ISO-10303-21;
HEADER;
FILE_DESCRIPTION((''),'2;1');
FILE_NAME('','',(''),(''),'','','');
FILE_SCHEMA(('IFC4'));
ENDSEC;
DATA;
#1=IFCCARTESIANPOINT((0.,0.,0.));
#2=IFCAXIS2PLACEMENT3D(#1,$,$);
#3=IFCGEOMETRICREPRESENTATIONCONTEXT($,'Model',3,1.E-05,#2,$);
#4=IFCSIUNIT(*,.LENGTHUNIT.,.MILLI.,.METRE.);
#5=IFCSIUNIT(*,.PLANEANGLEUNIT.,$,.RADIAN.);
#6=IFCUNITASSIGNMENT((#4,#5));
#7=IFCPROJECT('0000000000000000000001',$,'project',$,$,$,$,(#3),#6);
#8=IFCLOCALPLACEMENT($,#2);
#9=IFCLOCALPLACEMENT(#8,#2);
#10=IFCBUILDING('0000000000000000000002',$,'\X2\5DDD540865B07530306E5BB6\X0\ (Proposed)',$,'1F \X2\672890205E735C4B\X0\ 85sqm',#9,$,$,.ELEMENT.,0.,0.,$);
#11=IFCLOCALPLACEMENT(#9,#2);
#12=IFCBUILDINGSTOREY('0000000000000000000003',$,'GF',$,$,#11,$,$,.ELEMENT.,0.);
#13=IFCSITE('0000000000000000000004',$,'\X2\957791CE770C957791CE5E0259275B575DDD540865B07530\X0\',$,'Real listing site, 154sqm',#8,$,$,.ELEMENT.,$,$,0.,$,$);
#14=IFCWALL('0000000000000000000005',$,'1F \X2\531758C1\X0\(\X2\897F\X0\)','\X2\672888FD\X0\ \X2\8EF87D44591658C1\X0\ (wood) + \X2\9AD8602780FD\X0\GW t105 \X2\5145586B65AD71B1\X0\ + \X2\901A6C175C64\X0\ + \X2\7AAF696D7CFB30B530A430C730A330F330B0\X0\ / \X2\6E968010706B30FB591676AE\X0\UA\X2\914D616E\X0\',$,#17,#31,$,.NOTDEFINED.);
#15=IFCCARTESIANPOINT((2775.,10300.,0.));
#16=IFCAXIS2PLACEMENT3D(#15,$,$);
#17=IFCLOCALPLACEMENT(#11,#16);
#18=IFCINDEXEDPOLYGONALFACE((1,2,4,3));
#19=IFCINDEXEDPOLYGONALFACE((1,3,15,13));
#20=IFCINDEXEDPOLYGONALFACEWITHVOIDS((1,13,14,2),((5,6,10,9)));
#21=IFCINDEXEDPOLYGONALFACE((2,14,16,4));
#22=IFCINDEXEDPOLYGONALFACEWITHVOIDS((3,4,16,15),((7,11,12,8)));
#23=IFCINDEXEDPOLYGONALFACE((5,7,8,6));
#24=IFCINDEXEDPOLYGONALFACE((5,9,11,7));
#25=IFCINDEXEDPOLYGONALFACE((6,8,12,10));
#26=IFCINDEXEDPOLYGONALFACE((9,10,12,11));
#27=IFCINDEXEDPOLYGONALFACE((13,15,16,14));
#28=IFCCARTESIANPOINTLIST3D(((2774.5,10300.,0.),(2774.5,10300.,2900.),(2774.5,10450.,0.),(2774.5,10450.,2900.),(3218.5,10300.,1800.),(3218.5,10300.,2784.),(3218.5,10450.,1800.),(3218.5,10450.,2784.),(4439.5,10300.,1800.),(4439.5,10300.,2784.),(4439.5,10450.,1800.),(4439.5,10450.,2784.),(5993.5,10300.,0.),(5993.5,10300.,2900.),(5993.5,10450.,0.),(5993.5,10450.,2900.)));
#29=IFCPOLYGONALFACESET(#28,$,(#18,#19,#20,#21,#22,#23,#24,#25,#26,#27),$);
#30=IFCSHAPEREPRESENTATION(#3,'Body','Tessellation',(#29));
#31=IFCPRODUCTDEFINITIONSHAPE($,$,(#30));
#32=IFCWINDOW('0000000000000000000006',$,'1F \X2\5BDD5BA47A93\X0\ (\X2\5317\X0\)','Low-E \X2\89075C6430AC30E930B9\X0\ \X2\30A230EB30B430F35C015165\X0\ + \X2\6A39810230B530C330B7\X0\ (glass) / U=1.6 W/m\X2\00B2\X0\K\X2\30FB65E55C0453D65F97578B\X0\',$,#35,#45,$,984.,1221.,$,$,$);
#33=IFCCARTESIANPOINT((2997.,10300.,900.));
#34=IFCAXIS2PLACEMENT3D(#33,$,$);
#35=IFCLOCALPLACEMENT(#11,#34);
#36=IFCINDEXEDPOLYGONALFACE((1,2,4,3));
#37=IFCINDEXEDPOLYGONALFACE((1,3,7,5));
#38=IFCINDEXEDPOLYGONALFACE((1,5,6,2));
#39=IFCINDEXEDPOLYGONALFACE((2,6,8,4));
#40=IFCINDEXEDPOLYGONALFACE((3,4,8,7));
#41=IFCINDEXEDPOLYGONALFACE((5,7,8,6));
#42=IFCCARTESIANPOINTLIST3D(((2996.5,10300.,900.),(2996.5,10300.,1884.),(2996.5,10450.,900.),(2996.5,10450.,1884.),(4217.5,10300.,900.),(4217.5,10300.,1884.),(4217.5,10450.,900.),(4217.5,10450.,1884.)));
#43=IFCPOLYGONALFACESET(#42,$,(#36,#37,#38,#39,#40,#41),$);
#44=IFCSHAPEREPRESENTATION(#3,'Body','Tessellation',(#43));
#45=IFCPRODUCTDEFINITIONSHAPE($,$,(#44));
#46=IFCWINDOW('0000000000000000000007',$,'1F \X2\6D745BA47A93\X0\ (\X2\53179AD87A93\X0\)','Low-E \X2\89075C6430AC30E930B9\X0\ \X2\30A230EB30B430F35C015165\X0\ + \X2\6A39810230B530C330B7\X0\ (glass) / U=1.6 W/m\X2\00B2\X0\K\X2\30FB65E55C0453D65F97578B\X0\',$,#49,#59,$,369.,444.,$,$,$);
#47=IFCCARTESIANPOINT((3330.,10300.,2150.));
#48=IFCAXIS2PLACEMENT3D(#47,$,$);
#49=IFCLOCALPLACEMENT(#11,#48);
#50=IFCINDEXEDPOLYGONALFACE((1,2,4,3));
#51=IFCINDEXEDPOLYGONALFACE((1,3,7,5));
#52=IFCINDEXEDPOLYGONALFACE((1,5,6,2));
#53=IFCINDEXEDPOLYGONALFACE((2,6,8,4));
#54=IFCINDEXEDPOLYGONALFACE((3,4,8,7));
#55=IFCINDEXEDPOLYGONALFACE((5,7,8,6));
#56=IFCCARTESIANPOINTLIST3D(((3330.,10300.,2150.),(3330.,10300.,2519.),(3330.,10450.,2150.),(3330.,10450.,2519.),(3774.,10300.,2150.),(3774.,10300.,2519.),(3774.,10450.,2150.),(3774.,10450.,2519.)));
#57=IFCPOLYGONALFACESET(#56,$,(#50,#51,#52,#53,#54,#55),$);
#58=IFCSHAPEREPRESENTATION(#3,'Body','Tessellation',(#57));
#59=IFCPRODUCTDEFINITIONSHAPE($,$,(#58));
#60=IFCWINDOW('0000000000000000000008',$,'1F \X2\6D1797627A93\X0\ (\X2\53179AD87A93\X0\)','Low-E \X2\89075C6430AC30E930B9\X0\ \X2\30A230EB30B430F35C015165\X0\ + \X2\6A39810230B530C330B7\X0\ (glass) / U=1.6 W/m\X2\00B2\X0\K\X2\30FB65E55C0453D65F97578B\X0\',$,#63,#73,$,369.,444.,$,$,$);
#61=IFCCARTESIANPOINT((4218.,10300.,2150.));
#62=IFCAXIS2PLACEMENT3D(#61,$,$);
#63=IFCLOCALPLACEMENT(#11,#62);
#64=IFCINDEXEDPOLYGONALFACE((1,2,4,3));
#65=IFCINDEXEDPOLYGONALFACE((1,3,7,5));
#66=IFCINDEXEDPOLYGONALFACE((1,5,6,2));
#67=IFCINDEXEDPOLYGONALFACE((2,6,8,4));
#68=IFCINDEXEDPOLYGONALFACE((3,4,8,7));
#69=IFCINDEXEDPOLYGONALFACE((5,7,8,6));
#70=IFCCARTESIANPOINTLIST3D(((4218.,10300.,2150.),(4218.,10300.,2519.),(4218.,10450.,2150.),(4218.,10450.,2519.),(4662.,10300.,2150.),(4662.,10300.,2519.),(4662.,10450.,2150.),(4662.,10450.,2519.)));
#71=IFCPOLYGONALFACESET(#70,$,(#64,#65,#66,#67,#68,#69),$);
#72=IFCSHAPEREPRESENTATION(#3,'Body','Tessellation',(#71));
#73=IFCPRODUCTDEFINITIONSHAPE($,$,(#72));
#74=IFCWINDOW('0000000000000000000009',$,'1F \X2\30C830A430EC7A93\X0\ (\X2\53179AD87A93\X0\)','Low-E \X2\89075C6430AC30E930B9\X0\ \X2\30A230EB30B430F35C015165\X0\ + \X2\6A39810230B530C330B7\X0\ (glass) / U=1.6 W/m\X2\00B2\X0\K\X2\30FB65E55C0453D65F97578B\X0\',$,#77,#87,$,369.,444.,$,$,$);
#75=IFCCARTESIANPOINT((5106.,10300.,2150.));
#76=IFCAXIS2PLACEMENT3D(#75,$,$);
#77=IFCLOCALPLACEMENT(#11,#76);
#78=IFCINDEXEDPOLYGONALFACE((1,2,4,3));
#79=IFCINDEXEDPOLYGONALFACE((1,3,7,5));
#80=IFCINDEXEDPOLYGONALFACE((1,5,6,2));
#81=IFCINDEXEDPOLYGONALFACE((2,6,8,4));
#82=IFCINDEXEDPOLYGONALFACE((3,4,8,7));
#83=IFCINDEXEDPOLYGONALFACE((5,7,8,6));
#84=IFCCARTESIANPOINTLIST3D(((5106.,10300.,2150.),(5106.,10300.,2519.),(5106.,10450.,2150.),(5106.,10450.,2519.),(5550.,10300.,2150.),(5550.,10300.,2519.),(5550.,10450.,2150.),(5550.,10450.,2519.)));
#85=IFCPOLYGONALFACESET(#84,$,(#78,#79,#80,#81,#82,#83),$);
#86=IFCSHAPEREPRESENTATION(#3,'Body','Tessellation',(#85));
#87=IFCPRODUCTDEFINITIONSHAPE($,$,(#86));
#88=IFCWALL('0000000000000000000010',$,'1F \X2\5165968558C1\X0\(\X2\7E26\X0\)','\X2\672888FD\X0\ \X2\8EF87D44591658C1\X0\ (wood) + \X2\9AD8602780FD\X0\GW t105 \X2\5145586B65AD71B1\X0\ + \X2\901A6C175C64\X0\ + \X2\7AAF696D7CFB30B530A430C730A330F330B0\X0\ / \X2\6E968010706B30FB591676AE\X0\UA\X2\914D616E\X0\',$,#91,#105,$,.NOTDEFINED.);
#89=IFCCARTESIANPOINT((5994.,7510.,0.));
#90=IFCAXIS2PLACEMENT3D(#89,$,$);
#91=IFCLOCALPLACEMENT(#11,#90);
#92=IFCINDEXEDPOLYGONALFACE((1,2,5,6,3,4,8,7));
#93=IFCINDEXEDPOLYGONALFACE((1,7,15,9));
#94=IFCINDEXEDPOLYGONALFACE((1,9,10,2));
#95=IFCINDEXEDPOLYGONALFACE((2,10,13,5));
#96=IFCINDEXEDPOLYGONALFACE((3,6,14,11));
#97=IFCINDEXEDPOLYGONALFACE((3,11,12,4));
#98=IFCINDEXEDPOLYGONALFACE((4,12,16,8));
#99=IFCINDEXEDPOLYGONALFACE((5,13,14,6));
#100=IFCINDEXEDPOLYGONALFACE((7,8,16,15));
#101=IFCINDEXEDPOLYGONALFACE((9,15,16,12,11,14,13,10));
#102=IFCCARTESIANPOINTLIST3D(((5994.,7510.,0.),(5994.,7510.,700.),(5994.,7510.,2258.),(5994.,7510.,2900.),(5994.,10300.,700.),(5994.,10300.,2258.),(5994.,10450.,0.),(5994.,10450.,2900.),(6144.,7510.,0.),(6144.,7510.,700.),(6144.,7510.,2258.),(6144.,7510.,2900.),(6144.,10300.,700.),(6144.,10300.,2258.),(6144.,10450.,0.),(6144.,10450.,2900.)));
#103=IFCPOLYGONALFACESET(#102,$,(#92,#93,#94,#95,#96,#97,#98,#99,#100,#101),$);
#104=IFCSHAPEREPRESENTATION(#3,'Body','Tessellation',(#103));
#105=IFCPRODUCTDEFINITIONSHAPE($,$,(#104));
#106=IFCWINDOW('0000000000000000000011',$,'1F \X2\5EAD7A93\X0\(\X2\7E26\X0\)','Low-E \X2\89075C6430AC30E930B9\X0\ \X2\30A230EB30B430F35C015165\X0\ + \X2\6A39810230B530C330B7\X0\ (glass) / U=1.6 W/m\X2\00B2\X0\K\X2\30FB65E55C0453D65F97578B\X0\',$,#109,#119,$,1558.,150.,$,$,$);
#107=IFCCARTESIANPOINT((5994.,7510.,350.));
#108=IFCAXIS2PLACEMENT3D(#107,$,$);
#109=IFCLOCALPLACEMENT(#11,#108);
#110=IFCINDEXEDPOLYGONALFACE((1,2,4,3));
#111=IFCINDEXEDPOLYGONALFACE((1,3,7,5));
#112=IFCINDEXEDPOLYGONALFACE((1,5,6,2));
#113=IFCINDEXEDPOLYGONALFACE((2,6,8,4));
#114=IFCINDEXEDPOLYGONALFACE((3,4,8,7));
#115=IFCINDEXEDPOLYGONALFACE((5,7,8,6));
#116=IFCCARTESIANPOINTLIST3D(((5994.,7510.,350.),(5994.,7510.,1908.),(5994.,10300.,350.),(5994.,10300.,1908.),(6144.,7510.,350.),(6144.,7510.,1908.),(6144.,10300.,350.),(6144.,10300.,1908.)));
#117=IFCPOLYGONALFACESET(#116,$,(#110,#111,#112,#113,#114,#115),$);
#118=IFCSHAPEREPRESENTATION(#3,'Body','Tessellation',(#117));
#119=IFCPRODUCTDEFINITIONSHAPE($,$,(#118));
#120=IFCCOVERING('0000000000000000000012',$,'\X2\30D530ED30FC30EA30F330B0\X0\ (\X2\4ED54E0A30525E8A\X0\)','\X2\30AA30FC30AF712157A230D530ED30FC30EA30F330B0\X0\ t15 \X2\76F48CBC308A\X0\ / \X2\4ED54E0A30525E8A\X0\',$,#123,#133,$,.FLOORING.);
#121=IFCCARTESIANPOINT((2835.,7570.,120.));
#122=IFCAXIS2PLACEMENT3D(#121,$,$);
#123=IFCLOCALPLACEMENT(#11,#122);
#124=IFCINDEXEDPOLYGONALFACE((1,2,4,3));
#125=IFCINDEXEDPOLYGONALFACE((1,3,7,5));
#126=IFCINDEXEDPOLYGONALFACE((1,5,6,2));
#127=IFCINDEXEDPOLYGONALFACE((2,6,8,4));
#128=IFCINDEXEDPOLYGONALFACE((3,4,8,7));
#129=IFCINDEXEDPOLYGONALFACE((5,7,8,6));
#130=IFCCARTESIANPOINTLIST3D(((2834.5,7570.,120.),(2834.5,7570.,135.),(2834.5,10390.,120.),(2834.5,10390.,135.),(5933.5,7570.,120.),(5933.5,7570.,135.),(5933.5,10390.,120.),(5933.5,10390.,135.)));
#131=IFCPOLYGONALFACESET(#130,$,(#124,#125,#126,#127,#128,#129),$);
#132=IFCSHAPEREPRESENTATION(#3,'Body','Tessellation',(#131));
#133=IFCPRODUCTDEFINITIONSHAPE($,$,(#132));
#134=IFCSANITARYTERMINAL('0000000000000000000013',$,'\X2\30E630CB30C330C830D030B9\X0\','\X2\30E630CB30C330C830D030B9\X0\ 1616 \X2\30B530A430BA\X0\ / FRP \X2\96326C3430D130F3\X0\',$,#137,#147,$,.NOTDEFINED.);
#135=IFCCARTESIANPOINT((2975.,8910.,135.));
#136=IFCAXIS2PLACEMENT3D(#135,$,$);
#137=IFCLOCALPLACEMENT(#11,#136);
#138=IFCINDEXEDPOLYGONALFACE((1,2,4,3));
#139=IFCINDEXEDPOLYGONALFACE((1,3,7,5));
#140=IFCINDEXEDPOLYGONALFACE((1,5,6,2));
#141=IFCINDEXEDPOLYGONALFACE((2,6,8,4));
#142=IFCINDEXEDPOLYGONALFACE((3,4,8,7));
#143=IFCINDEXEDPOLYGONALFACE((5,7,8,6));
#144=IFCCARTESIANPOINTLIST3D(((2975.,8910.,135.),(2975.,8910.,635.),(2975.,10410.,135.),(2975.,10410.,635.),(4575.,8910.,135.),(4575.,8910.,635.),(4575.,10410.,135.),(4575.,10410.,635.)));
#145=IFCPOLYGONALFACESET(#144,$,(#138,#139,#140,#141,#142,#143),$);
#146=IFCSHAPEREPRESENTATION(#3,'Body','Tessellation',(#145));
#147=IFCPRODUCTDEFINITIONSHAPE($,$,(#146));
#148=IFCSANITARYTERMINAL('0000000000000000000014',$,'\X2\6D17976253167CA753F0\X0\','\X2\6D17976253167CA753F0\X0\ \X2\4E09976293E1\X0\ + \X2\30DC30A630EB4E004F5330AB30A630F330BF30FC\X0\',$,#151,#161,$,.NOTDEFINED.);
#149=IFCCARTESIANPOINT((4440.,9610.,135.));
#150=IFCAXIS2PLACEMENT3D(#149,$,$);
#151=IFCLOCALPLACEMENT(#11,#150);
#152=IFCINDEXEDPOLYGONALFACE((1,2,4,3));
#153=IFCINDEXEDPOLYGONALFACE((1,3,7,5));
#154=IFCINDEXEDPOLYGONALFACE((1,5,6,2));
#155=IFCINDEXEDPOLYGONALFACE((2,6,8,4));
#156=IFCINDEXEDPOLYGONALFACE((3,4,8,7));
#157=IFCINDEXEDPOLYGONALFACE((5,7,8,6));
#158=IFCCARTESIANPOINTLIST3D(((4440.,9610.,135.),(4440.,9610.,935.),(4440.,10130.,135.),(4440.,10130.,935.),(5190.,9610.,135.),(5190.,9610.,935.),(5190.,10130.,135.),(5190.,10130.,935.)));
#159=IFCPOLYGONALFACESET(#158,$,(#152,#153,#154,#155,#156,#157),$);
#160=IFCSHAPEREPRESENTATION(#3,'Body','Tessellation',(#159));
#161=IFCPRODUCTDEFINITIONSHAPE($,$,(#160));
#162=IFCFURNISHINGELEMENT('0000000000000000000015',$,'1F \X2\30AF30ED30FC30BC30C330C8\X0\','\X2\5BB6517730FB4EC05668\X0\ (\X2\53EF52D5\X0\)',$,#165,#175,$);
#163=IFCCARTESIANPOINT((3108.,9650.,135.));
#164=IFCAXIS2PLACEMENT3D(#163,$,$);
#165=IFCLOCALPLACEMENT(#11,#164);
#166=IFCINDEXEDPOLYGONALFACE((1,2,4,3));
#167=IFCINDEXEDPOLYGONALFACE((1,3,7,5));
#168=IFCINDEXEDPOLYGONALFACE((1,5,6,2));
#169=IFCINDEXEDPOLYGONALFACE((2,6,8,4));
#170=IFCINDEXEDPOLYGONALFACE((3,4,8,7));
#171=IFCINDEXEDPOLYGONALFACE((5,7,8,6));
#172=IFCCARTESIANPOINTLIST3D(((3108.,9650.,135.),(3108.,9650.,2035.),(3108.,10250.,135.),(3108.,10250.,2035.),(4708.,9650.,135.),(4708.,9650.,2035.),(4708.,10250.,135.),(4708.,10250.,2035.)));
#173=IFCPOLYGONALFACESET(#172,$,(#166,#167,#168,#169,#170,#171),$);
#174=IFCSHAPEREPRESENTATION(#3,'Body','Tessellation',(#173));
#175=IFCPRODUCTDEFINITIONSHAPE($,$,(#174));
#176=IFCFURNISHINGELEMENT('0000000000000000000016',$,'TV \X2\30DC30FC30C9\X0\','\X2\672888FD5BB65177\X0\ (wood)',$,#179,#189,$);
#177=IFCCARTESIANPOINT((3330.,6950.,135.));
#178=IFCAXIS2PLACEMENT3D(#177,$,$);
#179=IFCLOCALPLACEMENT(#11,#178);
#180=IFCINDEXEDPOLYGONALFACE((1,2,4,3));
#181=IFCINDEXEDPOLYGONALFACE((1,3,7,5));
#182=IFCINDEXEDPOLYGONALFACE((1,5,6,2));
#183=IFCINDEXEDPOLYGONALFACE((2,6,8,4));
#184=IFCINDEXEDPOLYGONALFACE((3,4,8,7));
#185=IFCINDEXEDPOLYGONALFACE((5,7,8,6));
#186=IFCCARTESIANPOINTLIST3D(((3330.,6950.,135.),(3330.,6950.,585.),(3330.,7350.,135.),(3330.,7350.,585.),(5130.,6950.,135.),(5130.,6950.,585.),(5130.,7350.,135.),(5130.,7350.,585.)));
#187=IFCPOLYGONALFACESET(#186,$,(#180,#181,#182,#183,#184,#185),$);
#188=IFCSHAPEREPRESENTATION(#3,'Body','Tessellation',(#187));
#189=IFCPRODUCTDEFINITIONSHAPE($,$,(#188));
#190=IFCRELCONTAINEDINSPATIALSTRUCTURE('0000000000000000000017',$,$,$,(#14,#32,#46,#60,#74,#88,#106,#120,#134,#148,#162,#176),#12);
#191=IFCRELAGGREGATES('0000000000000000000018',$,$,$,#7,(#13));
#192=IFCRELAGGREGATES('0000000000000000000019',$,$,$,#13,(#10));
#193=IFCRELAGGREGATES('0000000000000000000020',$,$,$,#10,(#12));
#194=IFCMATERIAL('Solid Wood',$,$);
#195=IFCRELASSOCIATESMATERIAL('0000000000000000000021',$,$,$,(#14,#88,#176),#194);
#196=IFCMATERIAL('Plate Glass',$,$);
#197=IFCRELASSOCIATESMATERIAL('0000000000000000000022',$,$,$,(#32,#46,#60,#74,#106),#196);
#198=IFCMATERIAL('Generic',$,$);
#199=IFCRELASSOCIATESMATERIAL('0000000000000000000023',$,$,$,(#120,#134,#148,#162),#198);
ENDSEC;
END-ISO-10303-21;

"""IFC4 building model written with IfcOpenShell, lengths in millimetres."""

from ifc_helpers import new_model, si_unit, frame, frame_2d, origin, place, context, project, spatial, rectangle, extrude, material, element, fill, save


model = new_model("IFC4")

# Units and contexts
model_context = context("Model", 3, precision=1e-05, world=origin())
ifc_project = project(units=[si_unit("LENGTHUNIT", "METRE", prefix="MILLI"), si_unit("PLANEANGLEUNIT", "RADIAN")], contexts=[model_context])

# Site, building, storey
site_placement = place(None, origin())
site = spatial("IfcSite", under=ifc_project, at=site_placement, Name="長野県長野市大字川合新田", ObjectType="Real listing site, 154sqm", CompositionType="ELEMENT", RefElevation=0.0)
building_placement = place(site_placement, origin())
building = spatial("IfcBuilding", under=site, at=building_placement, Name="川合新田の家 (Proposed)", ObjectType="1F 木造平屋 85sqm", CompositionType="ELEMENT", ElevationOfRefHeight=0.0, ElevationOfTerrain=0.0)
storey_placement = place(building_placement, origin())
storey = spatial("IfcBuildingStorey", under=building, at=storey_placement, Name="GF", CompositionType="ELEMENT", Elevation=0.0)

# Shared definitions
ifc_material_1 = material(Name="Solid Wood")

# Wall, openings, windows
wall_1_placement = place(storey_placement, frame((2775.0, 10300.0, 0.0)))
wall_1 = element("IfcWall", 1, at=wall_1_placement, inside=storey, material=ifc_material_1, Name="1F 北壁(西)", Description="木製 軸組外壁 (wood) + 高性能GW t105 充填断熱 + 通気層 + 窯業系サイディング / 準耐火・外皮UA配慮", PredefinedType="NOTDEFINED", context=model_context, shape_type="SweptSolid", body=[
    extrude(rectangle(XDim=3219.0, YDim=150.0, at=frame_2d((1609.0, 75.0))), frame((2775.0, 10300.0, 0.0)), (0.0, 0.0, 1.0), 2900.0),
])
opening_1_placement = place(storey_placement, frame((2997.0, 10300.0, 900.0)))
opening_1 = element("IfcOpeningElement", 2, at=opening_1_placement, cuts=wall_1, PredefinedType="NOTDEFINED", context=model_context, shape_type="SweptSolid", body=[
    extrude(rectangle(XDim=1221.0, YDim=150.0, at=frame_2d((610.0, 75.0))), frame((2997.0, 10300.0, 900.0)), (0.0, 0.0, 1.0), 984.0),
])
opening_2_placement = place(storey_placement, frame((3330.0, 10300.0, 2150.0)))
opening_2 = element("IfcOpeningElement", 3, at=opening_2_placement, cuts=wall_1, PredefinedType="NOTDEFINED", context=model_context, shape_type="SweptSolid", body=[
    extrude(rectangle(XDim=444.0, YDim=150.0, at=frame_2d((222.0, 75.0))), frame((3330.0, 10300.0, 2150.0)), (0.0, 0.0, 1.0), 369.0),
])
opening_3_placement = place(storey_placement, frame((4218.0, 10300.0, 2150.0)))
opening_3 = element("IfcOpeningElement", 4, at=opening_3_placement, cuts=wall_1, PredefinedType="NOTDEFINED", context=model_context, shape_type="SweptSolid", body=[
    extrude(rectangle(XDim=444.0, YDim=150.0, at=frame_2d((222.0, 75.0))), frame((4218.0, 10300.0, 2150.0)), (0.0, 0.0, 1.0), 369.0),
])
opening_4_placement = place(storey_placement, frame((5106.0, 10300.0, 2150.0)))
opening_4 = element("IfcOpeningElement", 5, at=opening_4_placement, cuts=wall_1, PredefinedType="NOTDEFINED", context=model_context, shape_type="SweptSolid", body=[
    extrude(rectangle(XDim=444.0, YDim=150.0, at=frame_2d((222.0, 75.0))), frame((5106.0, 10300.0, 2150.0)), (0.0, 0.0, 1.0), 369.0),
])
ifc_material_2 = material(Name="Plate Glass")
window_1_placement = place(storey_placement, frame((2997.0, 10300.0, 900.0)))
window_1 = element("IfcWindow", 6, at=window_1_placement, inside=storey, material=ifc_material_2, Name="1F 寝室窓 (北)", Description="Low-E 複層ガラス アルゴン封入 + 樹脂サッシ (glass) / U=1.6 W/m²K・日射取得型", OverallHeight=984.0, OverallWidth=1221.0, context=model_context, shape_type="SweptSolid", body=[
    extrude(rectangle(XDim=1221.0, YDim=150.0, at=frame_2d((610.0, 75.0))), frame((2997.0, 10300.0, 900.0)), (0.0, 0.0, 1.0), 984.0),
])
fill(opening_1, window_1)
window_2_placement = place(storey_placement, frame((3330.0, 10300.0, 2150.0)))
window_2 = element("IfcWindow", 7, at=window_2_placement, inside=storey, material=ifc_material_2, Name="1F 浴室窓 (北高窓)", Description="Low-E 複層ガラス アルゴン封入 + 樹脂サッシ (glass) / U=1.6 W/m²K・日射取得型", OverallHeight=369.0, OverallWidth=444.0, context=model_context, shape_type="SweptSolid", body=[
    extrude(rectangle(XDim=444.0, YDim=150.0, at=frame_2d((222.0, 75.0))), frame((3330.0, 10300.0, 2150.0)), (0.0, 0.0, 1.0), 369.0),
])
fill(opening_2, window_2)
window_3_placement = place(storey_placement, frame((4218.0, 10300.0, 2150.0)))
window_3 = element("IfcWindow", 8, at=window_3_placement, inside=storey, material=ifc_material_2, Name="1F 洗面窓 (北高窓)", Description="Low-E 複層ガラス アルゴン封入 + 樹脂サッシ (glass) / U=1.6 W/m²K・日射取得型", OverallHeight=369.0, OverallWidth=444.0, context=model_context, shape_type="SweptSolid", body=[
    extrude(rectangle(XDim=444.0, YDim=150.0, at=frame_2d((222.0, 75.0))), frame((4218.0, 10300.0, 2150.0)), (0.0, 0.0, 1.0), 369.0),
])
fill(opening_3, window_3)
window_4_placement = place(storey_placement, frame((5106.0, 10300.0, 2150.0)))
window_4 = element("IfcWindow", 9, at=window_4_placement, inside=storey, material=ifc_material_2, Name="1F トイレ窓 (北高窓)", Description="Low-E 複層ガラス アルゴン封入 + 樹脂サッシ (glass) / U=1.6 W/m²K・日射取得型", OverallHeight=369.0, OverallWidth=444.0, context=model_context, shape_type="SweptSolid", body=[
    extrude(rectangle(XDim=444.0, YDim=150.0, at=frame_2d((222.0, 75.0))), frame((5106.0, 10300.0, 2150.0)), (0.0, 0.0, 1.0), 369.0),
])
fill(opening_4, window_4)

# Wall, opening, window
wall_2_placement = place(storey_placement, frame((5994.0, 7510.0, 0.0)))
wall_2 = element("IfcWall", 10, at=wall_2_placement, inside=storey, material=ifc_material_1, Name="1F 入隅壁(縦)", Description="木製 軸組外壁 (wood) + 高性能GW t105 充填断熱 + 通気層 + 窯業系サイディング / 準耐火・外皮UA配慮", PredefinedType="NOTDEFINED", context=model_context, shape_type="SweptSolid", body=[
    extrude(rectangle(XDim=150.0, YDim=2940.0, at=frame_2d((75.0, 1470.0))), frame((5994.0, 7510.0, 0.0)), (0.0, 0.0, 1.0), 2900.0),
])
opening_5_placement = place(storey_placement, frame((5994.0, 7510.0, 350.0)))
opening_5 = element("IfcOpeningElement", 11, at=opening_5_placement, cuts=wall_2, PredefinedType="NOTDEFINED", context=model_context, shape_type="SweptSolid", body=[
    extrude(rectangle(XDim=150.0, YDim=2790.0, at=frame_2d((75.0, 1395.0))), frame((5994.0, 7510.0, 350.0)), (0.0, 0.0, 1.0), 1558.0),
])
window_5_placement = place(storey_placement, frame((5994.0, 7510.0, 350.0)))
window_5 = element("IfcWindow", 12, at=window_5_placement, inside=storey, material=ifc_material_2, Name="1F 庭窓(縦)", Description="Low-E 複層ガラス アルゴン封入 + 樹脂サッシ (glass) / U=1.6 W/m²K・日射取得型", OverallHeight=1558.0, OverallWidth=150.0, context=model_context, shape_type="SweptSolid", body=[
    extrude(rectangle(XDim=150.0, YDim=2790.0, at=frame_2d((75.0, 1395.0))), frame((5994.0, 7510.0, 350.0)), (0.0, 0.0, 1.0), 1558.0),
])
fill(opening_5, window_5)

# Covering
ifc_material_3 = material(Name="Generic")
covering_placement = place(storey_placement, frame((2835.0, 7570.0, 120.0)))
element("IfcCovering", 13, at=covering_placement, inside=storey, material=ifc_material_3, Name="フローリング (仕上げ床)", Description="オーク無垢フローリング t15 直貼り / 仕上げ床", PredefinedType="FLOORING", context=model_context, shape_type="SweptSolid", body=[
    extrude(rectangle(XDim=3099.0, YDim=2820.0, at=frame_2d((1549.0, 1410.0))), frame((2835.0, 7570.0, 120.0)), (0.0, 0.0, 1.0), 15.0),
])

# Sanitary terminals
sanitary_terminal_1_placement = place(storey_placement, frame((2975.0, 8910.0, 135.0)))
element("IfcSanitaryTerminal", 14, at=sanitary_terminal_1_placement, inside=storey, material=ifc_material_3, Name="ユニットバス", Description="ユニットバス 1616 サイズ / FRP 防水パン", PredefinedType="NOTDEFINED", context=model_context, shape_type="SweptSolid", body=[
    extrude(rectangle(XDim=1600.0, YDim=1500.0, at=frame_2d((800.0, 750.0))), frame((2975.0, 8910.0, 135.0)), (0.0, 0.0, 1.0), 500.0),
])
sanitary_terminal_2_placement = place(storey_placement, frame((4440.0, 9610.0, 135.0)))
element("IfcSanitaryTerminal", 15, at=sanitary_terminal_2_placement, inside=storey, material=ifc_material_3, Name="洗面化粧台", Description="洗面化粧台 三面鏡 + ボウル一体カウンター", PredefinedType="NOTDEFINED", context=model_context, shape_type="SweptSolid", body=[
    extrude(rectangle(XDim=750.0, YDim=520.0, at=frame_2d((375.0, 260.0))), frame((4440.0, 9610.0, 135.0)), (0.0, 0.0, 1.0), 800.0),
])

# Furnishing elements
furnishing_1_placement = place(storey_placement, frame((3108.0, 9650.0, 135.0)))
element("IfcFurnishingElement", 16, at=furnishing_1_placement, inside=storey, material=ifc_material_3, Name="1F クローゼット", Description="家具・什器 (可動)", context=model_context, shape_type="SweptSolid", body=[
    extrude(rectangle(XDim=1600.0, YDim=600.0, at=frame_2d((800.0, 300.0))), frame((3108.0, 9650.0, 135.0)), (0.0, 0.0, 1.0), 1900.0),
])
furnishing_2_placement = place(storey_placement, frame((3330.0, 6950.0, 135.0)))
element("IfcFurnishingElement", 17, at=furnishing_2_placement, inside=storey, material=ifc_material_1, Name="TV ボード", Description="木製家具 (wood)", context=model_context, shape_type="SweptSolid", body=[
    extrude(rectangle(XDim=1800.0, YDim=400.0, at=frame_2d((900.0, 200.0))), frame((3330.0, 6950.0, 135.0)), (0.0, 0.0, 1.0), 450.0),
])

save(model, "model.ifc")
